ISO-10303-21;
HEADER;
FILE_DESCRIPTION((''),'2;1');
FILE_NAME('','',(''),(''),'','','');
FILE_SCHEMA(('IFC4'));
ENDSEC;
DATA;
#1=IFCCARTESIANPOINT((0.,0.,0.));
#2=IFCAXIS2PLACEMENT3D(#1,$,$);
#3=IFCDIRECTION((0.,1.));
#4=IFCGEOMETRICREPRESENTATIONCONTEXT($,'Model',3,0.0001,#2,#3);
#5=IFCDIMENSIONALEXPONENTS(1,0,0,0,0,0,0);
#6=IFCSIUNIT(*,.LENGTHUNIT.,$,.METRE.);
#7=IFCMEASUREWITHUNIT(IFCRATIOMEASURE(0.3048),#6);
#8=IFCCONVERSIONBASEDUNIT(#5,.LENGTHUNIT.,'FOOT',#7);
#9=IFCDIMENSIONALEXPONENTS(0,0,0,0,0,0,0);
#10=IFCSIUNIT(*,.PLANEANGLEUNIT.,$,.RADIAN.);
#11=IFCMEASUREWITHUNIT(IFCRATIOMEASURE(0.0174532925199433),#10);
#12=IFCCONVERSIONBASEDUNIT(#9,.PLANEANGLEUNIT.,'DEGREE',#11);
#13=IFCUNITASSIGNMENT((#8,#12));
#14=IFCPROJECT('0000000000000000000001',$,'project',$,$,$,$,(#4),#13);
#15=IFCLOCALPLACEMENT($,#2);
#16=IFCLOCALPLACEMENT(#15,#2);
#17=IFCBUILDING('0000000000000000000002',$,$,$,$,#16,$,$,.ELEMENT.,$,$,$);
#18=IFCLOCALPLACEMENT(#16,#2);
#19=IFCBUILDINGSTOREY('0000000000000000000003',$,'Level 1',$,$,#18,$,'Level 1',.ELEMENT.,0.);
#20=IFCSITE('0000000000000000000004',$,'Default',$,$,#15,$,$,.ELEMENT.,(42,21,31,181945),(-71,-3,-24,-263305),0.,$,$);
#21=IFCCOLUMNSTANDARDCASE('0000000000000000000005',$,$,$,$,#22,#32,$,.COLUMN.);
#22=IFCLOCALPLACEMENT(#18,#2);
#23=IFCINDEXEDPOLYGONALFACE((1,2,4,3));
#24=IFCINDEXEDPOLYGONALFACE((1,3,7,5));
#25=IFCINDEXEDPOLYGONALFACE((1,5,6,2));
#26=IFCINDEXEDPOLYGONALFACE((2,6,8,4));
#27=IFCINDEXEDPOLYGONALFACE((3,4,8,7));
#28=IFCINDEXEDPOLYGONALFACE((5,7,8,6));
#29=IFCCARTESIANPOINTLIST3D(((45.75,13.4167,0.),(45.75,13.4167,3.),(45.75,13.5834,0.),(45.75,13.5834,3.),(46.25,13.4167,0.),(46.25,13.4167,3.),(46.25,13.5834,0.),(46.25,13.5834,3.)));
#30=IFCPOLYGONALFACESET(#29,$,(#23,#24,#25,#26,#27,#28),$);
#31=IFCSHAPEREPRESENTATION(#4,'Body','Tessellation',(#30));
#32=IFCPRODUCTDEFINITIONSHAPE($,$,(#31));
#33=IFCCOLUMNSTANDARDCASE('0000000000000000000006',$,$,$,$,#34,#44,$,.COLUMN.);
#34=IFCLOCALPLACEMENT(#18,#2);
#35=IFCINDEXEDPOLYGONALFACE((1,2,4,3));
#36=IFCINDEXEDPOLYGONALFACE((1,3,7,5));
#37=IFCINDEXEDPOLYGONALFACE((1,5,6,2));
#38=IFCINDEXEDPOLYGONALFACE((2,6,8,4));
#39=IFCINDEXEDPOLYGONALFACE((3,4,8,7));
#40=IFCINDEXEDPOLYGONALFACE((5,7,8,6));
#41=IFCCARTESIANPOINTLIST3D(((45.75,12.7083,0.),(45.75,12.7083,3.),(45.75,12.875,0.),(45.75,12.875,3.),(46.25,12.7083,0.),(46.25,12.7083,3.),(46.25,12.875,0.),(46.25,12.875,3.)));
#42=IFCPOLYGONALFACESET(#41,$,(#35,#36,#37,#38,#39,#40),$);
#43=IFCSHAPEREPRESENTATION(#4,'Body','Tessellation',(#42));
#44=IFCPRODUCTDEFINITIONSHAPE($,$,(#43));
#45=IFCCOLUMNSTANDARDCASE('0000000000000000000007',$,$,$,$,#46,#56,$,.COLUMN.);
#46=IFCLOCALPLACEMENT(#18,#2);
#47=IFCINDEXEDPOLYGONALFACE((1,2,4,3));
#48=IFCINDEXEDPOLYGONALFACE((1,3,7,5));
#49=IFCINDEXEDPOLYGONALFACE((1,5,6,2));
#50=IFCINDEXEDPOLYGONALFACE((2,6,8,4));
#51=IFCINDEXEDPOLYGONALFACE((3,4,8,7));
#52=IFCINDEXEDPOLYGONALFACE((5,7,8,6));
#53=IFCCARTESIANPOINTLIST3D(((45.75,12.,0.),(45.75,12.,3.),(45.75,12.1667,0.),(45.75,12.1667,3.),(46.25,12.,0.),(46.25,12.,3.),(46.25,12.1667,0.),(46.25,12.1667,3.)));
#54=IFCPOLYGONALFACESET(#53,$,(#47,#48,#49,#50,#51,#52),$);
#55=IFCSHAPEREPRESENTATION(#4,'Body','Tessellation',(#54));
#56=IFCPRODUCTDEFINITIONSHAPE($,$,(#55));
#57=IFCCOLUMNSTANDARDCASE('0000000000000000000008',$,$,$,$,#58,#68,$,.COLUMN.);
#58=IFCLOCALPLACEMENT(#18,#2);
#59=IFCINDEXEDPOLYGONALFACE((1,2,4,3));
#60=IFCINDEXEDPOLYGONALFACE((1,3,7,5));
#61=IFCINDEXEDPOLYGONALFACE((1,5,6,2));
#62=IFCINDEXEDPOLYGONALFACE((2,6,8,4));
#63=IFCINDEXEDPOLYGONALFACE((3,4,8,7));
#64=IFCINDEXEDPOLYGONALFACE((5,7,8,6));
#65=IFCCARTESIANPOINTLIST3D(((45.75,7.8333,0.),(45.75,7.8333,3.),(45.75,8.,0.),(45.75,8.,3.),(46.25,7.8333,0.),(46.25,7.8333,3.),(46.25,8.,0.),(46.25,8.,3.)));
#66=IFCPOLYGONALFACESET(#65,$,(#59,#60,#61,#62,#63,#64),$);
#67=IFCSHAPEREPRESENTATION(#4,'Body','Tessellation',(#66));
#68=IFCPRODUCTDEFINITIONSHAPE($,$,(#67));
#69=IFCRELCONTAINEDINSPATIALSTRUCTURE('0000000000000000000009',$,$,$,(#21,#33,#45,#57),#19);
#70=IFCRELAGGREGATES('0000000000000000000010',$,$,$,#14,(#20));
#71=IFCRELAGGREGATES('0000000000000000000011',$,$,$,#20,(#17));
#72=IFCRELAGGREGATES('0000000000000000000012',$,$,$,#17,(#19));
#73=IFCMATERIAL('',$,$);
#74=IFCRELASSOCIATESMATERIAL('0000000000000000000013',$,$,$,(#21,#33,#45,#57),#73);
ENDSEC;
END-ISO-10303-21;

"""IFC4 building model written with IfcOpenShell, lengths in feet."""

from ifc_helpers import new_model, entity, si_unit, converted_unit, direction, frame, origin, place, context, project, spatial, rectangle, extrude, material, element, save


model = new_model("IFC4")

# Units and contexts
model_context = context("Model", 3, precision=0.0001, world=origin(), true_north=direction((0.0, 1.0)))
ifc_project = project(units=[converted_unit("LENGTHUNIT", "FOOT", entity("IfcRatioMeasure", 0.3048), si_unit("LENGTHUNIT", "METRE"), dimensions=[1, 0, 0, 0, 0, 0, 0]), converted_unit("PLANEANGLEUNIT", "DEGREE", entity("IfcRatioMeasure", 0.0174532925199433), si_unit("PLANEANGLEUNIT", "RADIAN"), dimensions=[0, 0, 0, 0, 0, 0, 0])], contexts=[model_context])

# Site, building, storey
site_placement = place(None, origin())
site = spatial("IfcSite", under=ifc_project, at=site_placement, Name="Default", CompositionType="ELEMENT", RefLatitude=(42, 21, 31, 181945), RefLongitude=(-71, -3, -24, -263305), RefElevation=0.0)
building_placement = place(site_placement, origin())
building = spatial("IfcBuilding", under=site, at=building_placement, CompositionType="ELEMENT")
storey_placement = place(building_placement, origin())
storey = spatial("IfcBuildingStorey", under=building, at=storey_placement, Name="Level 1", LongName="Level 1", CompositionType="ELEMENT", Elevation=0.0)

# Columns
placement = place(storey_placement, frame((46.0, 46.25, 0.0), z_axis=(0.0, 0.0, 1.0), x_axis=(0.0, -1.0, 0.0)))
ifc_material_1 = material(Name="")
for number, where, z_axis, x_axis in (
    (1, (32.75, 0.0, 0.0), (0.0, 0.0, 1.0), (1.0, 0.0, 0.0)),
    (2, (33.4583, 0.0, 0.0), (0.0, 0.0, 1.0), (1.0, 0.0, 0.0)),
    (3, (34.1667, 0.0, 0.0), (0.0, 0.0, 1.0), (1.0, 0.0, 0.0)),
    (4, (38.3334, 0.0, 0.0), (0.0, 0.0, 1.0), (1.0, 0.0, 0.0)),
):
    element("IfcColumnStandardCase", number, at=place(placement, frame(where, z_axis=z_axis, x_axis=x_axis)), inside=storey, material=ifc_material_1, PredefinedType="COLUMN", context=model_context, shape_type="SweptSolid", body=[
        extrude(rectangle(XDim=0.1667, YDim=0.5), origin(), (0.0, 0.0, 1.0), 3.0),
    ])

save(model, "model.ifc")
